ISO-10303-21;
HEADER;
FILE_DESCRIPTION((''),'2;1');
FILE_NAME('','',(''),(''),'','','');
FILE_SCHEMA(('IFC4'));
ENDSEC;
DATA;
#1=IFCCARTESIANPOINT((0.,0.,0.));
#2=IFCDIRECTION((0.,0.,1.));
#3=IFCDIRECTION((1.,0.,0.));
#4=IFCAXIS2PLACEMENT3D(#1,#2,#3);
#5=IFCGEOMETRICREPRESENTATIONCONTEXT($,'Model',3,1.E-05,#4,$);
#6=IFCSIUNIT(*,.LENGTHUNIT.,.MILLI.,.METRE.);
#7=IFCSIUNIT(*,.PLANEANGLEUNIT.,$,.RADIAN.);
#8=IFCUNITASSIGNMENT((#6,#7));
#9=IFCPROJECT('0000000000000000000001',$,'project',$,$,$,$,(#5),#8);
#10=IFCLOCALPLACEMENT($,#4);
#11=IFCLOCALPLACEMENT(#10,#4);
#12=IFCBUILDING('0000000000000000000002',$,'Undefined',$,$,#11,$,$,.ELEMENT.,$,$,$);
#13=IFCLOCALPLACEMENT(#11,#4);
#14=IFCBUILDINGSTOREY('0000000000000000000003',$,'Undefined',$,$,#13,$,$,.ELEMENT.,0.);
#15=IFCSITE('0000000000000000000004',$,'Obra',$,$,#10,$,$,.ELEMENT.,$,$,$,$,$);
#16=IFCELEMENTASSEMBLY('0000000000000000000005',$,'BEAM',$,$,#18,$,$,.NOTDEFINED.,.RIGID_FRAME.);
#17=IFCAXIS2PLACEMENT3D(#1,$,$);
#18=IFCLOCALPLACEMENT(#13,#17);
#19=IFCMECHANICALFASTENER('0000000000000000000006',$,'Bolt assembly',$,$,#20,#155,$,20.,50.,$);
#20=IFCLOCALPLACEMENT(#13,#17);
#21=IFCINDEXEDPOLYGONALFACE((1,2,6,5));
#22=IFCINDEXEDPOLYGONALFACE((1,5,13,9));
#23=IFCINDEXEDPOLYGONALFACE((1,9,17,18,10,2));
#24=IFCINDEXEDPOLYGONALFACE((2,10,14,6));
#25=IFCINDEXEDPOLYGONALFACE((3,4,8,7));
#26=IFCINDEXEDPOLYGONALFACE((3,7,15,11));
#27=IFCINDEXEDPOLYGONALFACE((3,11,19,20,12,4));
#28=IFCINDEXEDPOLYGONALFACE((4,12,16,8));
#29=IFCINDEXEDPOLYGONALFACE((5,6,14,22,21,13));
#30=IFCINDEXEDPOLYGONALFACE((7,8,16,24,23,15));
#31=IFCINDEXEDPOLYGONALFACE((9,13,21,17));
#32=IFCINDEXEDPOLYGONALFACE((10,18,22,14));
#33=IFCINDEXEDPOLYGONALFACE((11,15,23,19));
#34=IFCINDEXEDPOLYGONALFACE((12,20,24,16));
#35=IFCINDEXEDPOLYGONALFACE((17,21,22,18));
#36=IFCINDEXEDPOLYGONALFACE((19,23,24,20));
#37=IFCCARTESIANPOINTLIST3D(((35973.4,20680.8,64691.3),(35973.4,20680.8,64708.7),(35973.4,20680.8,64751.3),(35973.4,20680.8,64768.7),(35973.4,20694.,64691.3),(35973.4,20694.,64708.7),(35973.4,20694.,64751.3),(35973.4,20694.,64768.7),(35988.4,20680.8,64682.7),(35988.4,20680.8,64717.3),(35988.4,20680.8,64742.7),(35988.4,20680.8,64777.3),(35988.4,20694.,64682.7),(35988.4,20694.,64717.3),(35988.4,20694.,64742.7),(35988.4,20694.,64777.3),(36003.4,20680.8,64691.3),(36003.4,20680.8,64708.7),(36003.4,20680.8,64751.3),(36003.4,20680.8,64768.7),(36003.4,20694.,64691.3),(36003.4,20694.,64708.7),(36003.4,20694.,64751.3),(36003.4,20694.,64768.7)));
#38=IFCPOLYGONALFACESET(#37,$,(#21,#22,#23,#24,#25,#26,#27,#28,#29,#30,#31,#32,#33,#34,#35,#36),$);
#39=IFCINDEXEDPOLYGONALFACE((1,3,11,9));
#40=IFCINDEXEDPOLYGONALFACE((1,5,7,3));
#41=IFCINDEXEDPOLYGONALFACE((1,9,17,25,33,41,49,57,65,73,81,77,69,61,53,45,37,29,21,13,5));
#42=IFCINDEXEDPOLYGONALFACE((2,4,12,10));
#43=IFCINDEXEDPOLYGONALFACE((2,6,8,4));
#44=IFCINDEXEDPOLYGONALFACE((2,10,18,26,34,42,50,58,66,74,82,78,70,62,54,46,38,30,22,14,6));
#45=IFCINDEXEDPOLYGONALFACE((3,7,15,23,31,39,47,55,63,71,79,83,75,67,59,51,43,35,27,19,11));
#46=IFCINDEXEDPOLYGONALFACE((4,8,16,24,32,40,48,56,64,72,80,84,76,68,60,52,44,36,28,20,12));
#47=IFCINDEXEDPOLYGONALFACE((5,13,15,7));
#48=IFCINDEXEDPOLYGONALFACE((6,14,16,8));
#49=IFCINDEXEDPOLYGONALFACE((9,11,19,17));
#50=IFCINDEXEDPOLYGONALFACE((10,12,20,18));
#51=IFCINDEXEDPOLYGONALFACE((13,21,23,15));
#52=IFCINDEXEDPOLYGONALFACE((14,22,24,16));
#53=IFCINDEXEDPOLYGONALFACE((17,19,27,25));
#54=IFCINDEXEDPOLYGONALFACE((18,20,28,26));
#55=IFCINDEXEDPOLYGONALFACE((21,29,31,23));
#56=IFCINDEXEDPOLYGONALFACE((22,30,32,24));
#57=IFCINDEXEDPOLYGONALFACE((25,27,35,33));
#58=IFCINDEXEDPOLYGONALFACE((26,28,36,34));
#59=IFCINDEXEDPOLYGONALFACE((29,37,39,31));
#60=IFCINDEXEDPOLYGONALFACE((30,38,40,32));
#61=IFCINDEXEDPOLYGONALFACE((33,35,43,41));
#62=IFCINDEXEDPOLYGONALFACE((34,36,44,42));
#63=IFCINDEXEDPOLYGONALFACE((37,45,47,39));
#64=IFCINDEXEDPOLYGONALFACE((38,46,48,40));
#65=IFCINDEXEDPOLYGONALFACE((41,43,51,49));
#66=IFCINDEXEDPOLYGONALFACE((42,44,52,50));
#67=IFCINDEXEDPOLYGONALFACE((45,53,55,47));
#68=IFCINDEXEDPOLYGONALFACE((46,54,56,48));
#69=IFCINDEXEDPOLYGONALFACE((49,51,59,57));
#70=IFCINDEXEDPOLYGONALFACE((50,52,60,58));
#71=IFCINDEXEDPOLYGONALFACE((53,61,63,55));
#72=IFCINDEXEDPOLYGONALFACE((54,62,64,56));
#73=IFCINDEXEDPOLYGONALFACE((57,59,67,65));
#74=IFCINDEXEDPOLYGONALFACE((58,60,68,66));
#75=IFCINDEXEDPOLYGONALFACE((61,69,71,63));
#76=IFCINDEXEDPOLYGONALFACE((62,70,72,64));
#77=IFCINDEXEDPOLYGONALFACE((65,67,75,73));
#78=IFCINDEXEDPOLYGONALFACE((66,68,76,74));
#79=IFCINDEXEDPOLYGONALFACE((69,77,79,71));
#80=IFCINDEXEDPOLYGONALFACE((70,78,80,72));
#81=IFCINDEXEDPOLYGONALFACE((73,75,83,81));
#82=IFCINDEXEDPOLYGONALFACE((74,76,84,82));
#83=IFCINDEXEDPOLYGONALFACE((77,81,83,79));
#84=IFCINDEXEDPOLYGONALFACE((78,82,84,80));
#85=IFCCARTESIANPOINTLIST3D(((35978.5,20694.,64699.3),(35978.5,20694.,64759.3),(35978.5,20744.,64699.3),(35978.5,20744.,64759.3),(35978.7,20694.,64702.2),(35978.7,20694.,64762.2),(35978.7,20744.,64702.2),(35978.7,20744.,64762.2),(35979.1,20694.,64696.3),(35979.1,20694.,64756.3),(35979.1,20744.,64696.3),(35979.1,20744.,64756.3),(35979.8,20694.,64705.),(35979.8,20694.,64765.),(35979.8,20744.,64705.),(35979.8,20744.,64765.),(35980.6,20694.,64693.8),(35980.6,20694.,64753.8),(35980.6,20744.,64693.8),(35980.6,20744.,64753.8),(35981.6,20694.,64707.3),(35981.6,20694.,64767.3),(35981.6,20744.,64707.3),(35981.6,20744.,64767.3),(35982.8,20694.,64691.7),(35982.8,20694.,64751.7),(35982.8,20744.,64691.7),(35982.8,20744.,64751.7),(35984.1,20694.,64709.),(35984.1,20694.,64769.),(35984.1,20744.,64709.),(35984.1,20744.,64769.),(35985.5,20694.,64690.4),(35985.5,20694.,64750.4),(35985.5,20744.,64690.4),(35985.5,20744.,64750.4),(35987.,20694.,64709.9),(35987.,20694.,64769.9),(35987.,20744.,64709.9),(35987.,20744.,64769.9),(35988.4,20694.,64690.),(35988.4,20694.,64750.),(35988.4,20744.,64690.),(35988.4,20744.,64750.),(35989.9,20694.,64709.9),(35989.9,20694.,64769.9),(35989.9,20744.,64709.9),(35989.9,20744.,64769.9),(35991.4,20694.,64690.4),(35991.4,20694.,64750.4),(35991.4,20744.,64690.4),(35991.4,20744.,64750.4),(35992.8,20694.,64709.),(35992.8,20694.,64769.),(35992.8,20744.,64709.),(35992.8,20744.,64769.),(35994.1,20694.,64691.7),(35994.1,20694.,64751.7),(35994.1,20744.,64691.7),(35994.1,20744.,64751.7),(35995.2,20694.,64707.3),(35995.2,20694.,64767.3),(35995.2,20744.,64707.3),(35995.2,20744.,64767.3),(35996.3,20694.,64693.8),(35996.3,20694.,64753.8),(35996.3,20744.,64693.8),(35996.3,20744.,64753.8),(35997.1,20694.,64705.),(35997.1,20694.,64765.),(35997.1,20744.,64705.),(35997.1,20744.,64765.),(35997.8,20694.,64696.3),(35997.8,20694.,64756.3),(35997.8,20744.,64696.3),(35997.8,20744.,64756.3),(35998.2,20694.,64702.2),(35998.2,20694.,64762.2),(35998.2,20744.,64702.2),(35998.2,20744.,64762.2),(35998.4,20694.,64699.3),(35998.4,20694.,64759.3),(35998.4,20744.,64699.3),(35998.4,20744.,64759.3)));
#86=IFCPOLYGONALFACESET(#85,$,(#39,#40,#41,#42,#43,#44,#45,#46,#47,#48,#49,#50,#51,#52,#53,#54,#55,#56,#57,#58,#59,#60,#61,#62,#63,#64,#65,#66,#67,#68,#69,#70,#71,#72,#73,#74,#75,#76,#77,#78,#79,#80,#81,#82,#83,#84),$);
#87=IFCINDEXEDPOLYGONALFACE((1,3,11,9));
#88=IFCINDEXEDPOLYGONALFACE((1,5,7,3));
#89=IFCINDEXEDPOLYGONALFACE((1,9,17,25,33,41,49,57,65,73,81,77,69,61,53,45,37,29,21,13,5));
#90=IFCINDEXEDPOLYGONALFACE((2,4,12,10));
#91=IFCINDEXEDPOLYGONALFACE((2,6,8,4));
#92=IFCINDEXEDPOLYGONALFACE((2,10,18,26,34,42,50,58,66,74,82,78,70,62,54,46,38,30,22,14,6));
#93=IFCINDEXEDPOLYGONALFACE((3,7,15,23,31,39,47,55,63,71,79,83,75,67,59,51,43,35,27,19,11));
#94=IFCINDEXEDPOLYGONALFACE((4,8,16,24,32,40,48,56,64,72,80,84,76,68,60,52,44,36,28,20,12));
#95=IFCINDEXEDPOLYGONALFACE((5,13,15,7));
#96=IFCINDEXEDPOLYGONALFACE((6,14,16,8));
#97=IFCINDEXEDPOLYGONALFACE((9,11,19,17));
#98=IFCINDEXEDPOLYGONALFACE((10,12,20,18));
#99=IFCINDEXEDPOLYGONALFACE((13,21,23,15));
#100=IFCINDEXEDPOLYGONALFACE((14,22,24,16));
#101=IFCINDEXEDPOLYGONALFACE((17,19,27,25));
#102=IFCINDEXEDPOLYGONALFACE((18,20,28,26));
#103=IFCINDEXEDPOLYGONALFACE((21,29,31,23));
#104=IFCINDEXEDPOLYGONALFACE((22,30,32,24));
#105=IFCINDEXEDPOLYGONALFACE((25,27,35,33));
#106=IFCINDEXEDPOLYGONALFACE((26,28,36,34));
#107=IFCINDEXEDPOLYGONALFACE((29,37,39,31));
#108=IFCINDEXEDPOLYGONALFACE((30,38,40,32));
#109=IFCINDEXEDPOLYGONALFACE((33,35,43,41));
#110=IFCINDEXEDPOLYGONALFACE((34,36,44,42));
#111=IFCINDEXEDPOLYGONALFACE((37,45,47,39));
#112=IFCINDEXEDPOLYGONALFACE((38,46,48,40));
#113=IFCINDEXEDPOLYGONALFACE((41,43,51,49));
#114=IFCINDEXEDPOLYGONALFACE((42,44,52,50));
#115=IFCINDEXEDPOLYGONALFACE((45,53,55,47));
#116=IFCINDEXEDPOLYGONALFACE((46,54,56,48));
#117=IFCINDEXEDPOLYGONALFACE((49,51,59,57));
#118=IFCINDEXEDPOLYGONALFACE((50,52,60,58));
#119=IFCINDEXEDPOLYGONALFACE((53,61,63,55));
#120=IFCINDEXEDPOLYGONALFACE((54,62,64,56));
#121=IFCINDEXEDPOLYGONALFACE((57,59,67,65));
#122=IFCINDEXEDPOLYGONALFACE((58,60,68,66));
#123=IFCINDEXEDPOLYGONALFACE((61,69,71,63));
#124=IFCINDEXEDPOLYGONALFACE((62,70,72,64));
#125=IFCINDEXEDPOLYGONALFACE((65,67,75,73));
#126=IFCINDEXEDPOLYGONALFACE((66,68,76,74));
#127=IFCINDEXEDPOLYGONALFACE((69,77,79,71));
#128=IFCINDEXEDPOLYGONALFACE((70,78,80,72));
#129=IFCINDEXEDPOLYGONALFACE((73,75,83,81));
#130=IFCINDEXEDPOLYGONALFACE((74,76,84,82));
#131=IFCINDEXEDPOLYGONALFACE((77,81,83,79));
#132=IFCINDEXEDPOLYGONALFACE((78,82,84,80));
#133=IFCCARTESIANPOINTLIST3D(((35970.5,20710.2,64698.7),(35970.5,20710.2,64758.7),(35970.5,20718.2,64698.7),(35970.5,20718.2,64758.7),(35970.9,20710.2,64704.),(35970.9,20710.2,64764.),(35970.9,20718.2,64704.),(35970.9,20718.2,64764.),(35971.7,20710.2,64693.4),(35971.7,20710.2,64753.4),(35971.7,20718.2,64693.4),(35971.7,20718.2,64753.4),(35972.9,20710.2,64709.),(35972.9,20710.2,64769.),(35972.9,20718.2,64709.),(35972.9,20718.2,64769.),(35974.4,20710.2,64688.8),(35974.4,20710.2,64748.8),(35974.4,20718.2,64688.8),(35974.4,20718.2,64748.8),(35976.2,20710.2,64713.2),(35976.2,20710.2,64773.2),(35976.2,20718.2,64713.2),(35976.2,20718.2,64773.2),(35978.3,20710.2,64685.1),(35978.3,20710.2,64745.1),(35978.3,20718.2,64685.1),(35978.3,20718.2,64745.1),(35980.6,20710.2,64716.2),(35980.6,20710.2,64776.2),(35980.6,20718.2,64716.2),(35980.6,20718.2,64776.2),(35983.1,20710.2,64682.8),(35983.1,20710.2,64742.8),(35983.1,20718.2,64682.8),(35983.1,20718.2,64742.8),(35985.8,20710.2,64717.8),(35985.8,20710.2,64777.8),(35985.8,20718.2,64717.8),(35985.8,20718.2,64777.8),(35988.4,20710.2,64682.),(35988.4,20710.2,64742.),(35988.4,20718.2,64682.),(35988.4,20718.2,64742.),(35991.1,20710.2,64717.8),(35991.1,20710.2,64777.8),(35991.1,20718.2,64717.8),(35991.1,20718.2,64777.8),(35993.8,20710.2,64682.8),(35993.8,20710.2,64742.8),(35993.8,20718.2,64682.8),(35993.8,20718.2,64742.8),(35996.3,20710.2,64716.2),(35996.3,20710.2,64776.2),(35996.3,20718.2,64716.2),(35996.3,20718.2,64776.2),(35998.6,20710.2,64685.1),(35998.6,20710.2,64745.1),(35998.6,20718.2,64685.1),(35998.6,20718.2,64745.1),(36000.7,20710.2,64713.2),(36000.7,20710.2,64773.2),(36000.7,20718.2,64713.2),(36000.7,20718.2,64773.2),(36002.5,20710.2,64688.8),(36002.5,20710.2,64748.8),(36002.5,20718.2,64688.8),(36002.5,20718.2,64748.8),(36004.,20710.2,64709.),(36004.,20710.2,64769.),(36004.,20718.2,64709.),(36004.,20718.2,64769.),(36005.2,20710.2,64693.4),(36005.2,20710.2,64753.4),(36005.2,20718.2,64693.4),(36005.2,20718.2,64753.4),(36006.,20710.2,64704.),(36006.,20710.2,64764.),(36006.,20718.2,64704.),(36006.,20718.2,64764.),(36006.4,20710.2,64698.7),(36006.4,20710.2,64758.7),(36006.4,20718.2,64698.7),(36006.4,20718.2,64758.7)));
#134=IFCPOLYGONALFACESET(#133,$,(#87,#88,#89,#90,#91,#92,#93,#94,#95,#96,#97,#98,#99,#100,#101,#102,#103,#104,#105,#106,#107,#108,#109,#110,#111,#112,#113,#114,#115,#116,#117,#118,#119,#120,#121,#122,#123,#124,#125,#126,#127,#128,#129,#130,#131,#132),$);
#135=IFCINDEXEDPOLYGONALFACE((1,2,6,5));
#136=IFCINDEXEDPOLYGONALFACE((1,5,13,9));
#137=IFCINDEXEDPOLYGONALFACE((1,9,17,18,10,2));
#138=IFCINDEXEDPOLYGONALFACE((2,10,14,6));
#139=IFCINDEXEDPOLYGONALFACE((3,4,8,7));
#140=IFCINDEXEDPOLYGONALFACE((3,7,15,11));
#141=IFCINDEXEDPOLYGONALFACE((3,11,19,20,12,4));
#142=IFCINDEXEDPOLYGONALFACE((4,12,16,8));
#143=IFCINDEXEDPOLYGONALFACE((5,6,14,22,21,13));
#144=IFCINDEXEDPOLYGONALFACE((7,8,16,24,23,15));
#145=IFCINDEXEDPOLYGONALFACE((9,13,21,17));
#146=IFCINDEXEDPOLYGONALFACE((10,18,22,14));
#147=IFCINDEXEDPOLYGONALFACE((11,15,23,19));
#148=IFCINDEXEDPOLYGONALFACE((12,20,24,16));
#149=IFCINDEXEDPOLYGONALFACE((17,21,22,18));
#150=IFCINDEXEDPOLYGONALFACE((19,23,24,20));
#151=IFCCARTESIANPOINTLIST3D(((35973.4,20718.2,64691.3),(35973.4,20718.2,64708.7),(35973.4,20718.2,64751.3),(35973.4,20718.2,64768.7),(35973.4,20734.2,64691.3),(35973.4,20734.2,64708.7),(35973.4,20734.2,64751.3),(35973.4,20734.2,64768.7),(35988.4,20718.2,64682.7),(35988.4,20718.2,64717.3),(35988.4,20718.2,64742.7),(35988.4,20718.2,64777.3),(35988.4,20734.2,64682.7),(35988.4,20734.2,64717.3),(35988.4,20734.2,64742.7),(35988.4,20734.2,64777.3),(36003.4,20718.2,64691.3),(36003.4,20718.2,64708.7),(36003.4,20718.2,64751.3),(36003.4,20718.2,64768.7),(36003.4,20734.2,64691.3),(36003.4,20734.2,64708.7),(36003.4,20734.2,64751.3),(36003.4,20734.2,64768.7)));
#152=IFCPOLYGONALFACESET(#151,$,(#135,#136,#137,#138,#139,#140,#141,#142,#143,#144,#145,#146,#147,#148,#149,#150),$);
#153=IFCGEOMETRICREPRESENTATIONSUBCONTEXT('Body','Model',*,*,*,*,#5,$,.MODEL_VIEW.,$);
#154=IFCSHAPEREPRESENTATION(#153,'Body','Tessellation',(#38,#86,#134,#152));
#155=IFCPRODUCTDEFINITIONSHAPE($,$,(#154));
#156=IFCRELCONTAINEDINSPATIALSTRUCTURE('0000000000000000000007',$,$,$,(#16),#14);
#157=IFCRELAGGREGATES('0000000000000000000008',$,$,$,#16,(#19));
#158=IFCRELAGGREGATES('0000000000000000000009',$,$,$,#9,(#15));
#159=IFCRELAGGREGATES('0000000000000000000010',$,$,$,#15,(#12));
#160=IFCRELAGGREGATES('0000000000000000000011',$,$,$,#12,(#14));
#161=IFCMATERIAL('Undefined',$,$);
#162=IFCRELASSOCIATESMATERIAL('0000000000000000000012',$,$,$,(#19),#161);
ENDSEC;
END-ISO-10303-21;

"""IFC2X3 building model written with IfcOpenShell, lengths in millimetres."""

from ifc_helpers import new_model, si_unit, frame, origin_with_axes, origin_2d_with_axis, place, context, subcontext, project, spatial, polyline, circle, outline, extrude, source, transform, mapped, material, element, aggregate, save


model = new_model("IFC2X3")

# Units and contexts
model_context = context("Model", 3, precision=1e-05, world=origin_with_axes())
body_context = subcontext(model_context, "Body", "Model", "MODEL_VIEW")
ifc_project = project(units=[si_unit("LENGTHUNIT", "METRE", prefix="MILLI"), si_unit("PLANEANGLEUNIT", "RADIAN")], contexts=[model_context])

# Site, building, storey
site_placement = place(None, origin_with_axes())
site = spatial("IfcSite", under=ifc_project, at=site_placement, Name="Obra", CompositionType="ELEMENT")
building_placement = place(site_placement, origin_with_axes())
building = spatial("IfcBuilding", under=site, at=building_placement, Name="Undefined", CompositionType="ELEMENT")
storey_placement = place(building_placement, origin_with_axes())
storey = spatial("IfcBuildingStorey", under=building, at=storey_placement, Name="Undefined", CompositionType="ELEMENT", Elevation=0.0)

# Shared definitions
ifc_material = material(Name="Undefined")

# Element assembly, mechanical fastener
assembly_1_placement = place(storey_placement, origin_with_axes())
assembly_1 = element("IfcElementAssembly", 1, at=assembly_1_placement, inside=storey, Name="BEAM", AssemblyPlace="NOTDEFINED", PredefinedType="RIGID_FRAME")
shared_shape_1 = source(origin_with_axes(), body_context, "Body", "SweptSolid", [
    extrude(outline(polyline([(17.3, 0.0), (8.7, 15.0), (-8.7, 15.0), (-17.3, 0.0), (-8.7, -15.0), (8.7, -15.0), (17.3, 0.0)])), frame((0.0, -26.3, 0.0), z_axis=(0.0, 1.0, 0.0), x_axis=(1.0, 0.0, 0.0)), (0.0, 0.0, 1.0), 13.2),
    extrude(circle(Radius=10.0, at=origin_2d_with_axis()), frame((0.0, -13.1, 0.0), z_axis=(0.0, 1.0, 0.0), x_axis=(1.0, 0.0, 0.0)), (0.0, 0.0, 1.0), 50.0),
    extrude(circle(Radius=18.0, at=origin_2d_with_axis()), frame((0.0, 3.1, 0.0), z_axis=(0.0, 1.0, 0.0), x_axis=(1.0, 0.0, 0.0)), (0.0, 0.0, 1.0), 8.0),
    extrude(outline(polyline([(17.3, 0.0), (8.7, 15.0), (-8.7, 15.0), (-17.3, 0.0), (-8.7, -15.0), (8.7, -15.0), (17.3, 0.0)])), frame((0.0, 11.1, 0.0), z_axis=(0.0, 1.0, 0.0), x_axis=(1.0, 0.0, 0.0)), (0.0, 0.0, 1.0), 16.0),
])
mechanical_fastener_1_placement = place(assembly_1_placement, frame((35948.4, 20707.1, 64850.0), z_axis=(1.0, 0.0, 0.0), x_axis=(0.0, 0.0, -1.0)))
mechanical_fastener_1 = element("IfcMechanicalFastener", 2, at=mechanical_fastener_1_placement, material=ifc_material, Name="Bolt assembly", NominalDiameter=20.0, NominalLength=50.0, context=body_context, shape_type="MappedRepresentation", body=[
    mapped(shared_shape_1, transform((90.0, 0.0, 40.0))),
    mapped(shared_shape_1, transform((150.0, 0.0, 40.0))),
])
aggregate(assembly_1, [mechanical_fastener_1])

save(model, "model.ifc")
